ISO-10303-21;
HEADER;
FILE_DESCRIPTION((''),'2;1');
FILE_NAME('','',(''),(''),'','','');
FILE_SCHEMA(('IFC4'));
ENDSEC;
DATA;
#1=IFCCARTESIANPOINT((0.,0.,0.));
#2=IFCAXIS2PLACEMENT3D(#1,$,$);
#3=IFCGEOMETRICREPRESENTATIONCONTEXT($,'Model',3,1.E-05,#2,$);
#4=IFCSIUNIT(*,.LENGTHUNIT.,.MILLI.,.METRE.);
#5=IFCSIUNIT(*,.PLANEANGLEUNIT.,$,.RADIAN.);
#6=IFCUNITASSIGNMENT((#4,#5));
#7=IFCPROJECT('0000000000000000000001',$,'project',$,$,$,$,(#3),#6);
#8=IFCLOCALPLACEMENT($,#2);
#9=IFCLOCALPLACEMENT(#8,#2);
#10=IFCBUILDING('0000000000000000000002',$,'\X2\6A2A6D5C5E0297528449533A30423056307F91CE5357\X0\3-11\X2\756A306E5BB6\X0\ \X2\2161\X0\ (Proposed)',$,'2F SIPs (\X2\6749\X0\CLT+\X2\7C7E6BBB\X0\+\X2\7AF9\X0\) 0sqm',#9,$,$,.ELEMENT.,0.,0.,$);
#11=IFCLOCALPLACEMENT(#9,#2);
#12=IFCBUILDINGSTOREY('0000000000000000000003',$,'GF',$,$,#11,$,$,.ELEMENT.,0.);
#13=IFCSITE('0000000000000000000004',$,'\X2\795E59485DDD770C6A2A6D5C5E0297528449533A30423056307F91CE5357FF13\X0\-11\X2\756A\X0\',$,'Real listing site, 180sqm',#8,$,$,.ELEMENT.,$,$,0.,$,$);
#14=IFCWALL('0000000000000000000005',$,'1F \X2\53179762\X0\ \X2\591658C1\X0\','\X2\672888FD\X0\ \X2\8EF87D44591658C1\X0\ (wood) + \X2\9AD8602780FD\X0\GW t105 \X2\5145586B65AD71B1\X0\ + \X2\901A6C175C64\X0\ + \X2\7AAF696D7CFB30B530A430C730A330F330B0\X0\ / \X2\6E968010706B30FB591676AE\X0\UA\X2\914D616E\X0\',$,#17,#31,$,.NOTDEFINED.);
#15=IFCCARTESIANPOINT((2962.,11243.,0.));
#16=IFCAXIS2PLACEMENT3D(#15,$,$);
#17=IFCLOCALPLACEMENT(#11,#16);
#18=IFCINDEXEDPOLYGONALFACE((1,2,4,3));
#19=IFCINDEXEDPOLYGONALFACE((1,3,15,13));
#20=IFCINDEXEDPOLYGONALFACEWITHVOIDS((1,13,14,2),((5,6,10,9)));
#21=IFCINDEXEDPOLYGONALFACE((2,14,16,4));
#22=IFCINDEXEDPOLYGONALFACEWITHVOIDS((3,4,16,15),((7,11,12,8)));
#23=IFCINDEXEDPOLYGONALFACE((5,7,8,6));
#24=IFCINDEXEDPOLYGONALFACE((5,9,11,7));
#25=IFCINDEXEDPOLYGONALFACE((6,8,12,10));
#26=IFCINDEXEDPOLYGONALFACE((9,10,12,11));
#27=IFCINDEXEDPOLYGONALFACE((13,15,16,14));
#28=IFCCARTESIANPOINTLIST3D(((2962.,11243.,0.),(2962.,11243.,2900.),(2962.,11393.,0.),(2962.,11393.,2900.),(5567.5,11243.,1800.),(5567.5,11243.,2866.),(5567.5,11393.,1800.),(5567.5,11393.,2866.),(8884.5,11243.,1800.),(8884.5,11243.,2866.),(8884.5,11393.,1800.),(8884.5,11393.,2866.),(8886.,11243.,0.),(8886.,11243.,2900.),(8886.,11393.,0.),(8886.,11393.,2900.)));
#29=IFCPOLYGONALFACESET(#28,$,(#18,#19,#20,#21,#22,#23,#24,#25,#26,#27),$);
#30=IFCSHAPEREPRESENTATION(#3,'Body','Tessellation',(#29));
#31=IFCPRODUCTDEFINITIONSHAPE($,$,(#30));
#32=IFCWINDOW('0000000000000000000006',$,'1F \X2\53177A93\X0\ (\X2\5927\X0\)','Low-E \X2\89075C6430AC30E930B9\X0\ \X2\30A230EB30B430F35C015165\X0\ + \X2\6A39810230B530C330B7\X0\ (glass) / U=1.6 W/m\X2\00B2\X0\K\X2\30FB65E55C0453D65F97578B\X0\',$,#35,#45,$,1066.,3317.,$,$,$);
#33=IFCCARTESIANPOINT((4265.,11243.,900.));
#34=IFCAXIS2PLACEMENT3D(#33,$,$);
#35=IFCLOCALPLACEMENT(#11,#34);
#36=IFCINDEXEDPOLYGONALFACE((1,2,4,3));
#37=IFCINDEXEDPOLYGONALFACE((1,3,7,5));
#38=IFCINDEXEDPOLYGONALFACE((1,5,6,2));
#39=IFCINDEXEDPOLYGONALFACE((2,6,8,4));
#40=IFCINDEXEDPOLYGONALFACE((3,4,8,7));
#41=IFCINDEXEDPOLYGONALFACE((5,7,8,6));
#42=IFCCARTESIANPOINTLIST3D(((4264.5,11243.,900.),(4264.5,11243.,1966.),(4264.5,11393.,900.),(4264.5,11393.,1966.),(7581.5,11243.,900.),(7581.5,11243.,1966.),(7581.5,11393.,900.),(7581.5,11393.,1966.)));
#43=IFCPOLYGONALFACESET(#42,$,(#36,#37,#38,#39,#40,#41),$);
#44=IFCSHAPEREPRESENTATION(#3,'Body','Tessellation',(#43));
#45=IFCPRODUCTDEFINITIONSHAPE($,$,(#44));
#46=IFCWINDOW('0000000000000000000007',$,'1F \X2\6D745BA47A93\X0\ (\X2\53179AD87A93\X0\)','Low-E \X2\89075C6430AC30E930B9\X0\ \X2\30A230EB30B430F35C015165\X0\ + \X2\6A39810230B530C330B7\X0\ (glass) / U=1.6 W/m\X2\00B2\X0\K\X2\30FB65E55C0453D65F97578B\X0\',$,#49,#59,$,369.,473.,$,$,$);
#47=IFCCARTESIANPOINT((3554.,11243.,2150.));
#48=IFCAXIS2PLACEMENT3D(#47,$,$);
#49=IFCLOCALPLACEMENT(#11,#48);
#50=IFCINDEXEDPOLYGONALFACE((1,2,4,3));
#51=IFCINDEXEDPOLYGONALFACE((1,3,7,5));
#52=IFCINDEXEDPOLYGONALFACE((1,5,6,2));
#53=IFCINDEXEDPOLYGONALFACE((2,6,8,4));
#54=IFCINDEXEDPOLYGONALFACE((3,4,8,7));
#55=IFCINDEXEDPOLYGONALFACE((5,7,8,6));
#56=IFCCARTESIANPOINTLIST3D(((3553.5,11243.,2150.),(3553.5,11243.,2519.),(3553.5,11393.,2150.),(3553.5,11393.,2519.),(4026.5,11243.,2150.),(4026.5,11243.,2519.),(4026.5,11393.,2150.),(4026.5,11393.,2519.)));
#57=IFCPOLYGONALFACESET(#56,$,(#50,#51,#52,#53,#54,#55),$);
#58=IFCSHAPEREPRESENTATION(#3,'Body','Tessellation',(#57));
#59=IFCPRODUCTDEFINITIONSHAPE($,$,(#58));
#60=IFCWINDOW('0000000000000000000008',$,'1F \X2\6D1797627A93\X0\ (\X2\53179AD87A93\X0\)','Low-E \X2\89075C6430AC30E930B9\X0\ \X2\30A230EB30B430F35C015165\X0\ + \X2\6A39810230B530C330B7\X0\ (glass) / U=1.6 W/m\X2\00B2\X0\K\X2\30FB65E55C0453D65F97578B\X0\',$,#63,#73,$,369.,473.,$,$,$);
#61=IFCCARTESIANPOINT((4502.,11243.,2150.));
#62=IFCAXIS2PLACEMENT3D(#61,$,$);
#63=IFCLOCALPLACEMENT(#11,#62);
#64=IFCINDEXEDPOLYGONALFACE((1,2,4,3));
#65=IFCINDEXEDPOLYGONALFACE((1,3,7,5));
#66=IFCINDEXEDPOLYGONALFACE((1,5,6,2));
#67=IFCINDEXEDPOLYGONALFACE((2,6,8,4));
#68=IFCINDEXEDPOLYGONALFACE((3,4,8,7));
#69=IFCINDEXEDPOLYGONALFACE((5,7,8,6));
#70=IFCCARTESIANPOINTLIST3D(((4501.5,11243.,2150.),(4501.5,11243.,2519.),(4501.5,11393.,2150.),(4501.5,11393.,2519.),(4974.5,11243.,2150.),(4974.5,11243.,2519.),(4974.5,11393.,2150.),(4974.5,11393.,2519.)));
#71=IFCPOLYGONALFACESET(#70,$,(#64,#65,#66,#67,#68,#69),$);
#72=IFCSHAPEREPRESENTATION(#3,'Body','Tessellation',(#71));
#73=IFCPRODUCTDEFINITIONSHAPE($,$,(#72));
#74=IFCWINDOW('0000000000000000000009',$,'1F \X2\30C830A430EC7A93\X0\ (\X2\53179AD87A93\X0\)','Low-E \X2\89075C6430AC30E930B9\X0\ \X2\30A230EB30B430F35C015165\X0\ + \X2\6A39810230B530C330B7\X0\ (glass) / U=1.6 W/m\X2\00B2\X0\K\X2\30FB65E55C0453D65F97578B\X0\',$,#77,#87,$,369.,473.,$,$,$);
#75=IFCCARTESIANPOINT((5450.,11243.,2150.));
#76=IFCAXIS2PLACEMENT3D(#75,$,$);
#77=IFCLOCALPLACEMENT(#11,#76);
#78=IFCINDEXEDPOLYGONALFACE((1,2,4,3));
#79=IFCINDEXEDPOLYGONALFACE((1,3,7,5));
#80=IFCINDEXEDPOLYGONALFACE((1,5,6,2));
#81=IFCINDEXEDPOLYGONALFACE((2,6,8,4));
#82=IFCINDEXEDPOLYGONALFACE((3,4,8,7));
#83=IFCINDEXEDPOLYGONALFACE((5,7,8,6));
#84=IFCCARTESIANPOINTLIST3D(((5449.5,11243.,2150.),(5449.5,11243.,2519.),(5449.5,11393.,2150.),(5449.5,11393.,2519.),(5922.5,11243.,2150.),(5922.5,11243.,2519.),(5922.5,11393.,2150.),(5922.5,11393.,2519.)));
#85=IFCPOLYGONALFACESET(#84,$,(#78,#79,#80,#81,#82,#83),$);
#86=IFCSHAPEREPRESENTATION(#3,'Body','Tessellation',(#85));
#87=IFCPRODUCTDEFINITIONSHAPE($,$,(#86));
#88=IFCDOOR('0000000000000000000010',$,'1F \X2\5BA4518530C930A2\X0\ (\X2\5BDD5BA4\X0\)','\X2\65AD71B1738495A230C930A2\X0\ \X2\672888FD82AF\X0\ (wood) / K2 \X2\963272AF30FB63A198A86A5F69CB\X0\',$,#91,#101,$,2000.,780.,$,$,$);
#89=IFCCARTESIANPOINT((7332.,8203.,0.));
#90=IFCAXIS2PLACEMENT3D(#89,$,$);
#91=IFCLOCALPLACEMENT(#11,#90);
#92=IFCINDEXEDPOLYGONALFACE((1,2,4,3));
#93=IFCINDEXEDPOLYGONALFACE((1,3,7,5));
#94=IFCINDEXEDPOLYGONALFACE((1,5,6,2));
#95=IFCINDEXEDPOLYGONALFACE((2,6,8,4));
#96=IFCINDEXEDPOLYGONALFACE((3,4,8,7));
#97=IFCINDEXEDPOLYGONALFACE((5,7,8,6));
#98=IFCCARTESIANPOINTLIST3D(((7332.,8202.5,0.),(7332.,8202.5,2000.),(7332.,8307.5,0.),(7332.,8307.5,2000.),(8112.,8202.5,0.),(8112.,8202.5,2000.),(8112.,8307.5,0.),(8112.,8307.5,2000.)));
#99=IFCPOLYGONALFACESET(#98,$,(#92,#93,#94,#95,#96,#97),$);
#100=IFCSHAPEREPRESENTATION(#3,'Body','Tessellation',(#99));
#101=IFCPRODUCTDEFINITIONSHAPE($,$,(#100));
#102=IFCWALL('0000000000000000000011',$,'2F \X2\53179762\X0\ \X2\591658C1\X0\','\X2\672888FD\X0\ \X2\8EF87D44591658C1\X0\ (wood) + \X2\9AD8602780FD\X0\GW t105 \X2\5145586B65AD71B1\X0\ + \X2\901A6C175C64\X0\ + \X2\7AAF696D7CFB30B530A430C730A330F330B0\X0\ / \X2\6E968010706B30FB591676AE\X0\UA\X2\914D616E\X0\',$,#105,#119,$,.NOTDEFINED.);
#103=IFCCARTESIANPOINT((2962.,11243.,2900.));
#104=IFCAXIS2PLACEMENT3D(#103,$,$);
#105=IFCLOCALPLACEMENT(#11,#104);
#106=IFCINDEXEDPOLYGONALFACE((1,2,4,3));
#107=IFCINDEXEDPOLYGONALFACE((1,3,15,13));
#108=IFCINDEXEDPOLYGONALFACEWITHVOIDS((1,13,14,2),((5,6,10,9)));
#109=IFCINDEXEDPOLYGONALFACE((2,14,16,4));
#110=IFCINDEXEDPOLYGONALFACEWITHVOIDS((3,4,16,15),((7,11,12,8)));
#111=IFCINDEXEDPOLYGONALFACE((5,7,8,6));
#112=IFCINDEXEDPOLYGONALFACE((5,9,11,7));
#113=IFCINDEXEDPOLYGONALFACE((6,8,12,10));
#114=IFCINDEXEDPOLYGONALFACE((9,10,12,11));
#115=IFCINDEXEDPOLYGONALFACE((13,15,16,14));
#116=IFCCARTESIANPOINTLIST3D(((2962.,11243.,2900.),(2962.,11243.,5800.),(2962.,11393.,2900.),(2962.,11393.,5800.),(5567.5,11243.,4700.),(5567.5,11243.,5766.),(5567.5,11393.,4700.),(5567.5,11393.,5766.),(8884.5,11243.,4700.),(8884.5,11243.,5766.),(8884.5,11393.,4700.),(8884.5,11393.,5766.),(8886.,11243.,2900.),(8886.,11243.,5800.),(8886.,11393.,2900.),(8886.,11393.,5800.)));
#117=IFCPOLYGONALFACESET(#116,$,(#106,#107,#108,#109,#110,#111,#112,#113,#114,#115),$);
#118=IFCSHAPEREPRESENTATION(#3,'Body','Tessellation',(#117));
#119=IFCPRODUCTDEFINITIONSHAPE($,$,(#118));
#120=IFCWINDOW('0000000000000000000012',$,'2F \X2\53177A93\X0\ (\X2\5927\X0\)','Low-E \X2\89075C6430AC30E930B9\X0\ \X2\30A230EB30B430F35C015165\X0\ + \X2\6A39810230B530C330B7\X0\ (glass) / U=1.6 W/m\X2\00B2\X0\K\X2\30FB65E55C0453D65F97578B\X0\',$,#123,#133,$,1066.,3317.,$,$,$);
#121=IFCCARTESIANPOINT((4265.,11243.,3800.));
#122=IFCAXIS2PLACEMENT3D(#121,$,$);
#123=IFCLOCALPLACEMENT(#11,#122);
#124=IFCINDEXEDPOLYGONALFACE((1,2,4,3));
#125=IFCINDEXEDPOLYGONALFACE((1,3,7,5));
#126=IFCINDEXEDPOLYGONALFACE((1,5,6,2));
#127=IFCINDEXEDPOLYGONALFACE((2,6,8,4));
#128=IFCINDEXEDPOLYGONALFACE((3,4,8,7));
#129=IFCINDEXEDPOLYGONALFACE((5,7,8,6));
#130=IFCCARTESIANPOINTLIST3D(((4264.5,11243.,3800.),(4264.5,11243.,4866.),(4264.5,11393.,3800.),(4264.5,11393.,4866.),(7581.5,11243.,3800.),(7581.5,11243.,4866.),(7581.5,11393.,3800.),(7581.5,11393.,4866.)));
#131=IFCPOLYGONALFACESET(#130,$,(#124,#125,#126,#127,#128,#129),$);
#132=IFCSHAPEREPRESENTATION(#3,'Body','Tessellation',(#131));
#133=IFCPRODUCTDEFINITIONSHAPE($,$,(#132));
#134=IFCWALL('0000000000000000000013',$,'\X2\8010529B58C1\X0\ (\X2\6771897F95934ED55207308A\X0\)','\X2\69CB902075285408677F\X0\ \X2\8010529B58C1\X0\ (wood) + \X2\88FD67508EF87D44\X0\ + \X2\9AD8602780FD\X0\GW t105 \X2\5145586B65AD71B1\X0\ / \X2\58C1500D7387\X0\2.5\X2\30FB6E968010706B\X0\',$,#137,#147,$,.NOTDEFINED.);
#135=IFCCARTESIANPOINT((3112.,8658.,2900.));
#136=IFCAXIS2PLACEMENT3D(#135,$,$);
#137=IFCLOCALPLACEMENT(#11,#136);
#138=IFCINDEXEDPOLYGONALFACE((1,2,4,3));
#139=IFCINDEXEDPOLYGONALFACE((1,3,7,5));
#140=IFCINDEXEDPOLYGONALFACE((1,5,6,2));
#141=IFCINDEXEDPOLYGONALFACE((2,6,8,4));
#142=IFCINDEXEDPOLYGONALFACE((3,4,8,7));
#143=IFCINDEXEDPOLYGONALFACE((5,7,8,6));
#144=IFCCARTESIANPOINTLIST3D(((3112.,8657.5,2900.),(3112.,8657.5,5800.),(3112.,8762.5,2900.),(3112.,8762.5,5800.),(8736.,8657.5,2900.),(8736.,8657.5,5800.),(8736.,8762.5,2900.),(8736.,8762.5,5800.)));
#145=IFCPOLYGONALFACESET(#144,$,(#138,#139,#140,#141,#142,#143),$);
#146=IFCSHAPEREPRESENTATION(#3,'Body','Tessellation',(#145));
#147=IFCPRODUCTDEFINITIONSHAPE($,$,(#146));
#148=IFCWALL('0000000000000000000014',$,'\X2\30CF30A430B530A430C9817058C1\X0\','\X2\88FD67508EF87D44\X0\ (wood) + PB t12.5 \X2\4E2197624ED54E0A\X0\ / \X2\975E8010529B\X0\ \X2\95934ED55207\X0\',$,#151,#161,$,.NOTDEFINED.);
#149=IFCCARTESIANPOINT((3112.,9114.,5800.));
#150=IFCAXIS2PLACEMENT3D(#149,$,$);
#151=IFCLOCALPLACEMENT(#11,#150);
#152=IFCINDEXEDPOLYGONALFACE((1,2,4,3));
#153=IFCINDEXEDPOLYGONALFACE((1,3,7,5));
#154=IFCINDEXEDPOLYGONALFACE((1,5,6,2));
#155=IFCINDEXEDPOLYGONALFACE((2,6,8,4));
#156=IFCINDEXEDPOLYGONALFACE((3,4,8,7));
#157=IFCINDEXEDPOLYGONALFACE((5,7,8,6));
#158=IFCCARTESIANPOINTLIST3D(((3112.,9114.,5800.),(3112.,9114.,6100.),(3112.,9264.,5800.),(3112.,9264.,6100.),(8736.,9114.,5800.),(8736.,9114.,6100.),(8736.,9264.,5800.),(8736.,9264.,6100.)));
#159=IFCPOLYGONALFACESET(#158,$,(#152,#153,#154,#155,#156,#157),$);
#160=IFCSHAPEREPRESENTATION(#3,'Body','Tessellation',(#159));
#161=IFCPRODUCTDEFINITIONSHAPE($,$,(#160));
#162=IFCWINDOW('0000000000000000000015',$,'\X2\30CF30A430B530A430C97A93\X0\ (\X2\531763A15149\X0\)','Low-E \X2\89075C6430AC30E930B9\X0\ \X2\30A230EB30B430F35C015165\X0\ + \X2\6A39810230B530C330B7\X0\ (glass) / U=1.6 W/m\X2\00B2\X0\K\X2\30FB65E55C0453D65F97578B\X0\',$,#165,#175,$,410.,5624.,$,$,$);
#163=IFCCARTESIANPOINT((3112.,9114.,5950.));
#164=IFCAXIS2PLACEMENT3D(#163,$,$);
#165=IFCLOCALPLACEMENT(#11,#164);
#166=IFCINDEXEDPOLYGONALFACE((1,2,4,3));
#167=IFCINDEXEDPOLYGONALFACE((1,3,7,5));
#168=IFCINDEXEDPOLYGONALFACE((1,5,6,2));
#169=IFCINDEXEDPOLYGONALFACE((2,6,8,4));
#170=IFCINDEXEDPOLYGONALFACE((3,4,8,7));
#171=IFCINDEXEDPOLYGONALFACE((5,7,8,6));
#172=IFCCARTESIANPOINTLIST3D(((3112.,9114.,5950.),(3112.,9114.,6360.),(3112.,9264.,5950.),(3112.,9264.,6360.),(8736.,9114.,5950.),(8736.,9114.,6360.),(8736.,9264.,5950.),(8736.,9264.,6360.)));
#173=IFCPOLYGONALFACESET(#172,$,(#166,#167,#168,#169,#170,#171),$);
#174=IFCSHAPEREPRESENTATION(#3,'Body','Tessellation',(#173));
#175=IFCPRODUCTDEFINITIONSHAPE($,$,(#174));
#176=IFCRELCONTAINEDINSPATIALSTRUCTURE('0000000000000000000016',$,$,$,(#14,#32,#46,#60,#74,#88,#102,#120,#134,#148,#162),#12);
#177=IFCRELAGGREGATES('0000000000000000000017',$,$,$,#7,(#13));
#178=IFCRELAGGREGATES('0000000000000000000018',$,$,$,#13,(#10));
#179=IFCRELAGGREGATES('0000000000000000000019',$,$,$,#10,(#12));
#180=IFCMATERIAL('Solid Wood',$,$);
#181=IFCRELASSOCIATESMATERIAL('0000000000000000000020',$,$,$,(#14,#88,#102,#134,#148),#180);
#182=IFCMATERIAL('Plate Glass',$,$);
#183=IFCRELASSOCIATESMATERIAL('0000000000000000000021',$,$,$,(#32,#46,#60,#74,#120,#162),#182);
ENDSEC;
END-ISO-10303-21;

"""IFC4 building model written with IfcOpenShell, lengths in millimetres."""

from ifc_helpers import new_model, si_unit, frame, frame_2d, origin, place, context, project, spatial, rectangle, extrude, material, element, fill, save


model = new_model("IFC4")

# Units and contexts
model_context = context("Model", 3, precision=1e-05, world=origin())
ifc_project = project(units=[si_unit("LENGTHUNIT", "METRE", prefix="MILLI"), si_unit("PLANEANGLEUNIT", "RADIAN")], contexts=[model_context])

# Site, building, storey
site_placement = place(None, origin())
site = spatial("IfcSite", under=ifc_project, at=site_placement, Name="神奈川県横浜市青葉区あざみ野南３-11番", ObjectType="Real listing site, 180sqm", CompositionType="ELEMENT", RefElevation=0.0)
building_placement = place(site_placement, origin())
building = spatial("IfcBuilding", under=site, at=building_placement, Name="横浜市青葉区あざみ野南3-11番の家 Ⅱ (Proposed)", ObjectType="2F SIPs (杉CLT+籾殻+竹) 0sqm", CompositionType="ELEMENT", ElevationOfRefHeight=0.0, ElevationOfTerrain=0.0)
storey_placement = place(building_placement, origin())
storey = spatial("IfcBuildingStorey", under=building, at=storey_placement, Name="GF", CompositionType="ELEMENT", Elevation=0.0)

# Wall, openings, windows
ifc_material_1 = material(Name="Solid Wood")
wall_1_placement = place(storey_placement, frame((2962.0, 11243.0, 0.0)))
wall_1 = element("IfcWall", 1, at=wall_1_placement, inside=storey, material=ifc_material_1, Name="1F 北面 外壁", Description="木製 軸組外壁 (wood) + 高性能GW t105 充填断熱 + 通気層 + 窯業系サイディング / 準耐火・外皮UA配慮", PredefinedType="NOTDEFINED", context=model_context, shape_type="SweptSolid", body=[
    extrude(rectangle(XDim=5924.0, YDim=150.0, at=frame_2d((2962.0, 75.0))), frame((2962.0, 11243.0, 0.0)), (0.0, 0.0, 1.0), 2900.0),
])
opening_1_placement = place(storey_placement, frame((4265.0, 11243.0, 900.0)))
opening_1 = element("IfcOpeningElement", 2, at=opening_1_placement, cuts=wall_1, PredefinedType="NOTDEFINED", context=model_context, shape_type="SweptSolid", body=[
    extrude(rectangle(XDim=3317.0, YDim=150.0, at=frame_2d((1658.0, 75.0))), frame((4265.0, 11243.0, 900.0)), (0.0, 0.0, 1.0), 1066.0),
])
opening_2_placement = place(storey_placement, frame((3554.0, 11243.0, 2150.0)))
opening_2 = element("IfcOpeningElement", 3, at=opening_2_placement, cuts=wall_1, PredefinedType="NOTDEFINED", context=model_context, shape_type="SweptSolid", body=[
    extrude(rectangle(XDim=473.0, YDim=150.0, at=frame_2d((236.0, 75.0))), frame((3554.0, 11243.0, 2150.0)), (0.0, 0.0, 1.0), 369.0),
])
opening_3_placement = place(storey_placement, frame((4502.0, 11243.0, 2150.0)))
opening_3 = element("IfcOpeningElement", 4, at=opening_3_placement, cuts=wall_1, PredefinedType="NOTDEFINED", context=model_context, shape_type="SweptSolid", body=[
    extrude(rectangle(XDim=473.0, YDim=150.0, at=frame_2d((236.0, 75.0))), frame((4502.0, 11243.0, 2150.0)), (0.0, 0.0, 1.0), 369.0),
])
opening_4_placement = place(storey_placement, frame((5450.0, 11243.0, 2150.0)))
opening_4 = element("IfcOpeningElement", 5, at=opening_4_placement, cuts=wall_1, PredefinedType="NOTDEFINED", context=model_context, shape_type="SweptSolid", body=[
    extrude(rectangle(XDim=473.0, YDim=150.0, at=frame_2d((236.0, 75.0))), frame((5450.0, 11243.0, 2150.0)), (0.0, 0.0, 1.0), 369.0),
])
ifc_material_2 = material(Name="Plate Glass")
window_1_placement = place(storey_placement, frame((4265.0, 11243.0, 900.0)))
window_1 = element("IfcWindow", 6, at=window_1_placement, inside=storey, material=ifc_material_2, Name="1F 北窓 (大)", Description="Low-E 複層ガラス アルゴン封入 + 樹脂サッシ (glass) / U=1.6 W/m²K・日射取得型", OverallHeight=1066.0, OverallWidth=3317.0, context=model_context, shape_type="SweptSolid", body=[
    extrude(rectangle(XDim=3317.0, YDim=150.0, at=frame_2d((1658.0, 75.0))), frame((4265.0, 11243.0, 900.0)), (0.0, 0.0, 1.0), 1066.0),
])
fill(opening_1, window_1)
window_2_placement = place(storey_placement, frame((3554.0, 11243.0, 2150.0)))
window_2 = element("IfcWindow", 7, at=window_2_placement, inside=storey, material=ifc_material_2, Name="1F 浴室窓 (北高窓)", Description="Low-E 複層ガラス アルゴン封入 + 樹脂サッシ (glass) / U=1.6 W/m²K・日射取得型", OverallHeight=369.0, OverallWidth=473.0, context=model_context, shape_type="SweptSolid", body=[
    extrude(rectangle(XDim=473.0, YDim=150.0, at=frame_2d((236.0, 75.0))), frame((3554.0, 11243.0, 2150.0)), (0.0, 0.0, 1.0), 369.0),
])
fill(opening_2, window_2)
window_3_placement = place(storey_placement, frame((4502.0, 11243.0, 2150.0)))
window_3 = element("IfcWindow", 8, at=window_3_placement, inside=storey, material=ifc_material_2, Name="1F 洗面窓 (北高窓)", Description="Low-E 複層ガラス アルゴン封入 + 樹脂サッシ (glass) / U=1.6 W/m²K・日射取得型", OverallHeight=369.0, OverallWidth=473.0, context=model_context, shape_type="SweptSolid", body=[
    extrude(rectangle(XDim=473.0, YDim=150.0, at=frame_2d((236.0, 75.0))), frame((4502.0, 11243.0, 2150.0)), (0.0, 0.0, 1.0), 369.0),
])
fill(opening_3, window_3)
window_4_placement = place(storey_placement, frame((5450.0, 11243.0, 2150.0)))
window_4 = element("IfcWindow", 9, at=window_4_placement, inside=storey, material=ifc_material_2, Name="1F トイレ窓 (北高窓)", Description="Low-E 複層ガラス アルゴン封入 + 樹脂サッシ (glass) / U=1.6 W/m²K・日射取得型", OverallHeight=369.0, OverallWidth=473.0, context=model_context, shape_type="SweptSolid", body=[
    extrude(rectangle(XDim=473.0, YDim=150.0, at=frame_2d((236.0, 75.0))), frame((5450.0, 11243.0, 2150.0)), (0.0, 0.0, 1.0), 369.0),
])
fill(opening_4, window_4)

# Door
door_1_placement = place(storey_placement, frame((7332.0, 8203.0, 0.0)))
element("IfcDoor", 10, at=door_1_placement, inside=storey, material=ifc_material_1, Name="1F 室内ドア (寝室)", Description="断熱玄関ドア 木製芯 (wood) / K2 防犯・採風機構", OverallHeight=2000.0, OverallWidth=780.0, context=model_context, shape_type="SweptSolid", body=[
    extrude(rectangle(XDim=780.0, YDim=105.0, at=frame_2d((390.0, 52.0))), frame((7332.0, 8203.0, 0.0)), (0.0, 0.0, 1.0), 2000.0),
])

# Wall, opening, window
wall_2_placement = place(storey_placement, frame((2962.0, 11243.0, 2900.0)))
wall_2 = element("IfcWall", 11, at=wall_2_placement, inside=storey, material=ifc_material_1, Name="2F 北面 外壁", Description="木製 軸組外壁 (wood) + 高性能GW t105 充填断熱 + 通気層 + 窯業系サイディング / 準耐火・外皮UA配慮", PredefinedType="NOTDEFINED", context=model_context, shape_type="SweptSolid", body=[
    extrude(rectangle(XDim=5924.0, YDim=150.0, at=frame_2d((2962.0, 75.0))), frame((2962.0, 11243.0, 2900.0)), (0.0, 0.0, 1.0), 2900.0),
])
opening_5_placement = place(storey_placement, frame((4265.0, 11243.0, 3800.0)))
opening_5 = element("IfcOpeningElement", 12, at=opening_5_placement, cuts=wall_2, PredefinedType="NOTDEFINED", context=model_context, shape_type="SweptSolid", body=[
    extrude(rectangle(XDim=3317.0, YDim=150.0, at=frame_2d((1658.0, 75.0))), frame((4265.0, 11243.0, 3800.0)), (0.0, 0.0, 1.0), 1066.0),
])
window_5_placement = place(storey_placement, frame((4265.0, 11243.0, 3800.0)))
window_5 = element("IfcWindow", 13, at=window_5_placement, inside=storey, material=ifc_material_2, Name="2F 北窓 (大)", Description="Low-E 複層ガラス アルゴン封入 + 樹脂サッシ (glass) / U=1.6 W/m²K・日射取得型", OverallHeight=1066.0, OverallWidth=3317.0, context=model_context, shape_type="SweptSolid", body=[
    extrude(rectangle(XDim=3317.0, YDim=150.0, at=frame_2d((1658.0, 75.0))), frame((4265.0, 11243.0, 3800.0)), (0.0, 0.0, 1.0), 1066.0),
])
fill(opening_5, window_5)

# Wall
wall_3_placement = place(storey_placement, frame((3112.0, 8658.0, 2900.0)))
element("IfcWall", 14, at=wall_3_placement, inside=storey, material=ifc_material_1, Name="耐力壁 (東西間仕切り)", Description="構造用合板 耐力壁 (wood) + 製材軸組 + 高性能GW t105 充填断熱 / 壁倍率2.5・準耐火", PredefinedType="NOTDEFINED", context=model_context, shape_type="SweptSolid", body=[
    extrude(rectangle(XDim=5624.0, YDim=105.0, at=frame_2d((2812.0, 52.0))), frame((3112.0, 8658.0, 2900.0)), (0.0, 0.0, 1.0), 2900.0),
])

# Wall, opening, window
wall_4_placement = place(storey_placement, frame((3112.0, 9114.0, 5800.0)))
wall_4 = element("IfcWall", 15, at=wall_4_placement, inside=storey, material=ifc_material_1, Name="ハイサイド腰壁", Description="製材軸組 (wood) + PB t12.5 両面仕上 / 非耐力 間仕切", PredefinedType="NOTDEFINED", context=model_context, shape_type="SweptSolid", body=[
    extrude(rectangle(XDim=5624.0, YDim=150.0, at=frame_2d((2812.0, 75.0))), frame((3112.0, 9114.0, 5800.0)), (0.0, 0.0, 1.0), 700.0),
])
opening_6_placement = place(storey_placement, frame((3112.0, 9114.0, 5950.0)))
opening_6 = element("IfcOpeningElement", 16, at=opening_6_placement, cuts=wall_4, PredefinedType="NOTDEFINED", context=model_context, shape_type="SweptSolid", body=[
    extrude(rectangle(XDim=5624.0, YDim=150.0, at=frame_2d((2812.0, 75.0))), frame((3112.0, 9114.0, 5950.0)), (0.0, 0.0, 1.0), 410.0),
])
window_6_placement = place(storey_placement, frame((3112.0, 9114.0, 5950.0)))
window_6 = element("IfcWindow", 17, at=window_6_placement, inside=storey, material=ifc_material_2, Name="ハイサイド窓 (北採光)", Description="Low-E 複層ガラス アルゴン封入 + 樹脂サッシ (glass) / U=1.6 W/m²K・日射取得型", OverallHeight=410.0, OverallWidth=5624.0, context=model_context, shape_type="SweptSolid", body=[
    extrude(rectangle(XDim=5624.0, YDim=150.0, at=frame_2d((2812.0, 75.0))), frame((3112.0, 9114.0, 5950.0)), (0.0, 0.0, 1.0), 410.0),
])
fill(opening_6, window_6)

save(model, "model.ifc")
